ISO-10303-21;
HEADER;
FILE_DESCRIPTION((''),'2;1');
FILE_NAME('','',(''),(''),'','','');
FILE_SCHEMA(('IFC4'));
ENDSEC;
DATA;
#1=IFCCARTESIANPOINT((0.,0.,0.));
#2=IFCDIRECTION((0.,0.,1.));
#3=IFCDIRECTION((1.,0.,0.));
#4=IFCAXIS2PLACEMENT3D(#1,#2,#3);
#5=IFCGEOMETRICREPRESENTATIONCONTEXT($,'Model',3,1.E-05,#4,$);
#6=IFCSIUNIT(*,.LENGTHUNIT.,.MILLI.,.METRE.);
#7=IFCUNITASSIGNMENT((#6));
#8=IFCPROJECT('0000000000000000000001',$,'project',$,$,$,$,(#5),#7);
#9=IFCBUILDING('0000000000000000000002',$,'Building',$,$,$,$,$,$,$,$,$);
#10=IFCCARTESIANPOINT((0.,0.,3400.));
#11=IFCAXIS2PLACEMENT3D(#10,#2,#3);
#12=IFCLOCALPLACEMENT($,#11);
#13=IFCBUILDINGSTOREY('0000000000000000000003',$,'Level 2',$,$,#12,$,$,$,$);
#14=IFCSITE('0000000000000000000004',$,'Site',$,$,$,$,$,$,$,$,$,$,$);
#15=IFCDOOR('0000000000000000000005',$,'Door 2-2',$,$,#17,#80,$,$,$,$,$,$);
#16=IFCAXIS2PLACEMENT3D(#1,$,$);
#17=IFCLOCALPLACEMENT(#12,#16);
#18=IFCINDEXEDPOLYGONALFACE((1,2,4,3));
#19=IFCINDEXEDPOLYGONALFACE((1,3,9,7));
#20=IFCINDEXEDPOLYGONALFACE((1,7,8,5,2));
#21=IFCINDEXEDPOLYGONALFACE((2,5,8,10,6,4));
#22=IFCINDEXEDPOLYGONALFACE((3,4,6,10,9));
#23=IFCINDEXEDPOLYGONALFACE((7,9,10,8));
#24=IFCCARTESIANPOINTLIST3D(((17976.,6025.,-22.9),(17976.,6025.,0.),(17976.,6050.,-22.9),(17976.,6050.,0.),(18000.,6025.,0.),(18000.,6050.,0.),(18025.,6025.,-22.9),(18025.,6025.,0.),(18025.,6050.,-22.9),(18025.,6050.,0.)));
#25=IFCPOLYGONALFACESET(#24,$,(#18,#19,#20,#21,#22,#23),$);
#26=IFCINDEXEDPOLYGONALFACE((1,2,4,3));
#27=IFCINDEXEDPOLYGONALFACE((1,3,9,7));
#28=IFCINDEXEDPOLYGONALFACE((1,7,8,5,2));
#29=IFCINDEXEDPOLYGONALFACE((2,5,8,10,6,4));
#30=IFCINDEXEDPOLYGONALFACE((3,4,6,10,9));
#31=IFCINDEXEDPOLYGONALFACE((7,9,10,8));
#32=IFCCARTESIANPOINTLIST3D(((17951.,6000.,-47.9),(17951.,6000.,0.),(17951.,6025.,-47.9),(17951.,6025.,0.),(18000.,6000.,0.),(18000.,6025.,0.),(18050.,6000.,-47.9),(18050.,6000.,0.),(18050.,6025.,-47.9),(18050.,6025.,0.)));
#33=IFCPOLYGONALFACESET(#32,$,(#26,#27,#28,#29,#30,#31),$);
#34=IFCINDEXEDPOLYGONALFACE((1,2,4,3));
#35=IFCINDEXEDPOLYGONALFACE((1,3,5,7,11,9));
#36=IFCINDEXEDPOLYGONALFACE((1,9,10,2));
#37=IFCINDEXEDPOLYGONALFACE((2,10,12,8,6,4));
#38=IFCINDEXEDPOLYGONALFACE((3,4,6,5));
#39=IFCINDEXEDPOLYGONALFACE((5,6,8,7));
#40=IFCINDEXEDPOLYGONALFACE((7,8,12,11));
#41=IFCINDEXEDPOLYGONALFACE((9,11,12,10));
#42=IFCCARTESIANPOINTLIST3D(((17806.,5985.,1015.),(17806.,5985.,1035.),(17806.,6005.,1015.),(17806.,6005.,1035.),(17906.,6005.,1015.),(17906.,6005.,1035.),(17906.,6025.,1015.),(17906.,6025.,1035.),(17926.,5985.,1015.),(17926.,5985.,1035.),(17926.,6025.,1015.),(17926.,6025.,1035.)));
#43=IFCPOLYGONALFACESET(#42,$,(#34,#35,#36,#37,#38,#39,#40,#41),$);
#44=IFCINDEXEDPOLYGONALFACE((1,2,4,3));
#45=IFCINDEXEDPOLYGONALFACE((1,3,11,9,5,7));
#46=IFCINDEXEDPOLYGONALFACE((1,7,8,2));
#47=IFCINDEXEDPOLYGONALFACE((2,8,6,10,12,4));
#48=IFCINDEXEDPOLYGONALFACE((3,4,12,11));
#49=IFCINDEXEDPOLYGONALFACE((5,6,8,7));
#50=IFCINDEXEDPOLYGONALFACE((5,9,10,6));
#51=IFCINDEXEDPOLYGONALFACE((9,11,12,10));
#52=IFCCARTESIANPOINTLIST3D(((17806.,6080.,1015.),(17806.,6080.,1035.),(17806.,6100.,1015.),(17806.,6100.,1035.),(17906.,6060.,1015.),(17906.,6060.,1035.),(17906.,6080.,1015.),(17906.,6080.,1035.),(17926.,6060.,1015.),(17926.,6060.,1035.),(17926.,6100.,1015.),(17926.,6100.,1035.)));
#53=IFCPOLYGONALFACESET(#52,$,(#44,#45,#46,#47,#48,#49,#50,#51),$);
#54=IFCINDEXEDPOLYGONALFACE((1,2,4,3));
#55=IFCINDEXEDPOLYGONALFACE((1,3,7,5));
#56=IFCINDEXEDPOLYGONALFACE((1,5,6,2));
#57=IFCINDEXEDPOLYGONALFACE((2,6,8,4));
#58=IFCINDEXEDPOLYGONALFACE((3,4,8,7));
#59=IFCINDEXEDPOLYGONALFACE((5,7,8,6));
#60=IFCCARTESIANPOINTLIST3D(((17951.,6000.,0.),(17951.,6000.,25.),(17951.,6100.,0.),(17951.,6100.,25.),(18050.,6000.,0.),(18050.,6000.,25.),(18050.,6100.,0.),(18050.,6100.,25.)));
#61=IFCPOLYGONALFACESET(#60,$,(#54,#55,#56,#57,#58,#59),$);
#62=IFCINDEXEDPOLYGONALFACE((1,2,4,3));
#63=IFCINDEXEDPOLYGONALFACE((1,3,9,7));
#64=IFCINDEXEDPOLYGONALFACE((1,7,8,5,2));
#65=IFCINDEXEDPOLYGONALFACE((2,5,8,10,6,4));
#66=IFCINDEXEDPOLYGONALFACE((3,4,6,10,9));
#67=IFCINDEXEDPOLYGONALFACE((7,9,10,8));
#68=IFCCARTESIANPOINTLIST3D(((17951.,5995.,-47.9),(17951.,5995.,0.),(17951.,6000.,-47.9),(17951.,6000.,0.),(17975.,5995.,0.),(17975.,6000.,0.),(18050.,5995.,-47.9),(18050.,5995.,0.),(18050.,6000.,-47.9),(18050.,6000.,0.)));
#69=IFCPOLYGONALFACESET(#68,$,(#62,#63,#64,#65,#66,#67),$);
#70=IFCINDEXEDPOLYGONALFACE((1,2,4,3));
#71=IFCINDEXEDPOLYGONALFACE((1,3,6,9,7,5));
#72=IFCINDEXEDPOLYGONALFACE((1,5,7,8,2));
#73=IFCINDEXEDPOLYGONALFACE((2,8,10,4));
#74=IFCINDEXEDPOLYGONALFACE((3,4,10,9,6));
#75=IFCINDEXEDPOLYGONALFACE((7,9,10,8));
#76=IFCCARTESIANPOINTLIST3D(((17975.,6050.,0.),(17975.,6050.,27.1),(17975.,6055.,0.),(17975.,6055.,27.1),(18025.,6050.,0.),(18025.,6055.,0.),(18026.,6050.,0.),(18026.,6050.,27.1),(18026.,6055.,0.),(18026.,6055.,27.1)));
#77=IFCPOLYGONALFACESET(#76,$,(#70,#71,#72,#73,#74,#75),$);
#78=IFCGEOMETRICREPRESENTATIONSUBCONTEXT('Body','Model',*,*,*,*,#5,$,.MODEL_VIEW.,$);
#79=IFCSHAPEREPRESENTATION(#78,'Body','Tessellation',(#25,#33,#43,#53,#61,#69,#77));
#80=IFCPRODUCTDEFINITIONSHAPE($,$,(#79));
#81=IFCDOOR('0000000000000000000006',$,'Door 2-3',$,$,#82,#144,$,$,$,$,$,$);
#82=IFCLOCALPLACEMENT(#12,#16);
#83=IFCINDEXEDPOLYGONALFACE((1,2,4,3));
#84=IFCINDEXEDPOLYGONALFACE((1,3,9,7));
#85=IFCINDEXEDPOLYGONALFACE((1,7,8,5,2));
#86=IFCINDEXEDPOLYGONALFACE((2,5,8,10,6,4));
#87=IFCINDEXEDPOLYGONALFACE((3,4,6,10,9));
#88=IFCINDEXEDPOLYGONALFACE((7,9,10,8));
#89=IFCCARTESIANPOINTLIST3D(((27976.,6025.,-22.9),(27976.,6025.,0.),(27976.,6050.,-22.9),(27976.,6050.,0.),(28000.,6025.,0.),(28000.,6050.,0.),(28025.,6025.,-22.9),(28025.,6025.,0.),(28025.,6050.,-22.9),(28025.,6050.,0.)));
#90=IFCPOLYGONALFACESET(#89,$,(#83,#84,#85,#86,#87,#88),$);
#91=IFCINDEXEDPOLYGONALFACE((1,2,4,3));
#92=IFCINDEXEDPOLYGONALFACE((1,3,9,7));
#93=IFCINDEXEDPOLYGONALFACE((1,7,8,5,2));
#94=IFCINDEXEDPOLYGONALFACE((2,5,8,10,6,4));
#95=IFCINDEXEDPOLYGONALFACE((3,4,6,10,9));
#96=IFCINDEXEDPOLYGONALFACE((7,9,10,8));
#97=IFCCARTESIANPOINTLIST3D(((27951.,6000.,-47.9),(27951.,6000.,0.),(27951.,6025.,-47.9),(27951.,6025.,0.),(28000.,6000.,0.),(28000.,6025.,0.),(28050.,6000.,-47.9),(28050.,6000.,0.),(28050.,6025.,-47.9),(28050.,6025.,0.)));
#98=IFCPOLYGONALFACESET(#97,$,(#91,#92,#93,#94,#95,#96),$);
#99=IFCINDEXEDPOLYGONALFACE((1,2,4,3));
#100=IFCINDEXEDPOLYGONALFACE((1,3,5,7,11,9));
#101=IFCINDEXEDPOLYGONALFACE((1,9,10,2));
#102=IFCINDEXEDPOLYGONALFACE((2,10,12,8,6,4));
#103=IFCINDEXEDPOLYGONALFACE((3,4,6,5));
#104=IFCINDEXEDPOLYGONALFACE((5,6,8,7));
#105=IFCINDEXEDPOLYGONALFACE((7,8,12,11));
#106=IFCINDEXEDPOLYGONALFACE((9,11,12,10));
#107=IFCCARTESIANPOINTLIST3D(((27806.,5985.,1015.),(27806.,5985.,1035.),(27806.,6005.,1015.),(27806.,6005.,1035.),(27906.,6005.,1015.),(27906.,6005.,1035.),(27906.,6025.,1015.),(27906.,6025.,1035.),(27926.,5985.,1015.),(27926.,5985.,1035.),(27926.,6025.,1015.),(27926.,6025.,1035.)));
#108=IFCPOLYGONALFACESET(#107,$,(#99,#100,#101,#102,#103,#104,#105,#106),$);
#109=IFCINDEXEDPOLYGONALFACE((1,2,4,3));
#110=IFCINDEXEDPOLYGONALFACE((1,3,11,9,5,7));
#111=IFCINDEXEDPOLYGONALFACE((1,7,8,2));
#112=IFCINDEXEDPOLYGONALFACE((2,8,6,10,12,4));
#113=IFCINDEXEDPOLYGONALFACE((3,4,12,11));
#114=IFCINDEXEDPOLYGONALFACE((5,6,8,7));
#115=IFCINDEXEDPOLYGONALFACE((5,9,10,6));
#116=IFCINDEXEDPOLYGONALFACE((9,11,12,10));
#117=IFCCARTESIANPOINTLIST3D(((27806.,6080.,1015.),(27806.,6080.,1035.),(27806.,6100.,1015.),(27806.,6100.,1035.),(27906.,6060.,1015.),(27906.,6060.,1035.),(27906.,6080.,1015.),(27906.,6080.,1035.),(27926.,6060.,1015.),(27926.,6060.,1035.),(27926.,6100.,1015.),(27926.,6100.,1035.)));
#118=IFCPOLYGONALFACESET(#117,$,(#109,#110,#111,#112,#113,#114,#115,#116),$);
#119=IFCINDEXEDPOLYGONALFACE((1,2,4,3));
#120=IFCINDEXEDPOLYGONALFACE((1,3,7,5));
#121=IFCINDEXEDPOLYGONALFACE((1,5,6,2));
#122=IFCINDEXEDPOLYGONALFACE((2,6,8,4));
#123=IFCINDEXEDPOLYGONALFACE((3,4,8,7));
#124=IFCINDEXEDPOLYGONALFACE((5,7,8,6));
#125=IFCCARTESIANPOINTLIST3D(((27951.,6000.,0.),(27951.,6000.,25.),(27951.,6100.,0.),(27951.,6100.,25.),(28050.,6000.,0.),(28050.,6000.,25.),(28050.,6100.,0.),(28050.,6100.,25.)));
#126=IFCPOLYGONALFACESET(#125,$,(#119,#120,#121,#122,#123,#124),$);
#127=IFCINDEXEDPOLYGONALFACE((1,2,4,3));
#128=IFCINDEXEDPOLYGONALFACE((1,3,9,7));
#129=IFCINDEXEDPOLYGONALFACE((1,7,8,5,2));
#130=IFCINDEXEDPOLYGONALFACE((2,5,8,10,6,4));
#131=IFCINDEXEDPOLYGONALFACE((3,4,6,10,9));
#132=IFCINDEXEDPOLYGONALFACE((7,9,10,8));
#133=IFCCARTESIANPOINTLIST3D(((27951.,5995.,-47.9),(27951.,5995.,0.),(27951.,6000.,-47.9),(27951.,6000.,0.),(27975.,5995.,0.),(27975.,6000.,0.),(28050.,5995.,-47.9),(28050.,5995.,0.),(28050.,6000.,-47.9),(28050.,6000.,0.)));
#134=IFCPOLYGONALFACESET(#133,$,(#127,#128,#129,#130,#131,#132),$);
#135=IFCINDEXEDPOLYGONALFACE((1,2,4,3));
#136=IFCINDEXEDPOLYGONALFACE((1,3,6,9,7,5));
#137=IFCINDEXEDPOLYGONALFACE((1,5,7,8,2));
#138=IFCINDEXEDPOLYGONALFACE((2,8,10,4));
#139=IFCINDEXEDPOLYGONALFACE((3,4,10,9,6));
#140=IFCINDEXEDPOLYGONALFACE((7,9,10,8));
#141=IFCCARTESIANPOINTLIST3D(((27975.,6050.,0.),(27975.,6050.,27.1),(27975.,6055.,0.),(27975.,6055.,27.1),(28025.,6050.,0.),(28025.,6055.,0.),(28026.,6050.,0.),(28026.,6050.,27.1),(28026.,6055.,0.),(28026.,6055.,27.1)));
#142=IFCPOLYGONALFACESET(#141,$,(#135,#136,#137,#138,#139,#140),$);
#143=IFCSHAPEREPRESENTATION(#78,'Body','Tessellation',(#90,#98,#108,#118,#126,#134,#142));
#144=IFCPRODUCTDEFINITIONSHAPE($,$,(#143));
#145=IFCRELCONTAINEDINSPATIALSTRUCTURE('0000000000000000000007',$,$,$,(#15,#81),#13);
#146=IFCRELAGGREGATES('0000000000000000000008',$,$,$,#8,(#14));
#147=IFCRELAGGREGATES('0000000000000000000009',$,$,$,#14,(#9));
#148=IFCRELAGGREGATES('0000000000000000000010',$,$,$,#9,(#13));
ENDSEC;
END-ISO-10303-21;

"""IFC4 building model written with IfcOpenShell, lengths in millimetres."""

from ifc_helpers import new_model, si_unit, frame, origin_with_axes, place, context, subcontext, project, spatial, line, indexed_curve, outline, extrude, element, save


model = new_model("IFC4")

# Units and contexts
model_context = context("Model", 3, precision=1e-05, world=origin_with_axes())
body_context = subcontext(model_context, "Body", "Model", "MODEL_VIEW")
ifc_project = project(units=[si_unit("LENGTHUNIT", "METRE", prefix="MILLI")], contexts=[model_context])

# Site, building, storey
site = spatial("IfcSite", under=ifc_project, Name="Site")
building = spatial("IfcBuilding", under=site, Name="Building")
storey_placement = place(None, frame((0.0, 0.0, 3400.0), z_axis=(0.0, 0.0, 1.0), x_axis=(1.0, 0.0, 0.0)))
storey = spatial("IfcBuildingStorey", under=building, at=storey_placement, Name="Level 2")

# Doors
door_1_placement = place(storey_placement, frame((18000.0, 6000.0, 0.0), z_axis=(0.0, 0.0, 1.0), x_axis=(1.0, 0.0, 0.0)))
element("IfcDoor", 1, at=door_1_placement, inside=storey, Name="Door 2-2", context=body_context, shape_type="SweptSolid", body=[
    extrude(outline(indexed_curve([(0.0, 0.0), (0.0, 2.1), (1.0, 2.1), (1.0, 0.0), (-24.0, 0.0), (-24.0, -22.9), (25.0, -22.9), (25.0, 0.0)], segments=[line(1, 2, 3, 4, 5, 6, 7, 8, 1)])), frame((0.0, 25.0, 0.0), z_axis=(0.0, -1.0, 0.0), x_axis=(1.0, 0.0, 0.0)), (0.0, 0.0, -1.0), 25.0),
    extrude(outline(indexed_curve([(0.0, 0.0), (0.0, 2.1), (1.0, 2.1), (1.0, 0.0), (-49.0, 0.0), (-49.0, -47.9), (50.0, -47.9), (50.0, 0.0)], segments=[line(1, 2, 3, 4, 5, 6, 7, 8, 1)])), frame((0.0, 0.0, 0.0), z_axis=(0.0, -1.0, 0.0), x_axis=(1.0, 0.0, 0.0)), (0.0, 0.0, -1.0), 25.0),
    extrude(outline(indexed_curve([(0.0, 0.0), (-49.0, 0.0), (-49.0, 35.0), (0.0, 35.0)], segments=[line(1, 2, 3, 4, 1)])), frame((25.0, 25.0, 25.0), z_axis=(0.0, 0.0, 1.0), x_axis=(1.0, 0.0, 0.0)), (0.0, 0.0, 1.0), -47.9),
    extrude(outline(indexed_curve([(0.0, 0.0), (0.0, -40.0), (-120.0, -40.0), (-120.0, -20.0), (-20.0, -20.0), (-20.0, 0.0)], segments=[line(1, 2, 3, 4, 5, 6, 1)])), frame((-74.0, 25.0, 1015.0), z_axis=(0.0, 0.0, 1.0), x_axis=(1.0, 0.0, 0.0)), (0.0, 0.0, 1.0), 20.0),
    extrude(outline(indexed_curve([(0.0, 0.0), (0.0, 40.0), (-120.0, 40.0), (-120.0, 20.0), (-20.0, 20.0), (-20.0, 0.0)], segments=[line(1, 2, 3, 4, 5, 6, 1)])), frame((-74.0, 60.0, 1015.0), z_axis=(0.0, 0.0, 1.0), x_axis=(1.0, 0.0, 0.0)), (0.0, 0.0, 1.0), 20.0),
    extrude(outline(indexed_curve([(0.0, 0.0), (-99.0, 0.0), (-99.0, 100.0), (0.0, 100.0)], segments=[line(1, 2, 3, 4, 1)])), frame((50.0, 0.0, 0.0), z_axis=(0.0, 0.0, 1.0), x_axis=(1.0, 0.0, 0.0)), (0.0, 0.0, 1.0), 25.0),
    extrude(outline(indexed_curve([(0.0, 0.0), (0.0, 27.1), (51.0, 27.1), (51.0, 0.0), (-24.0, 0.0), (-24.0, -47.9), (75.0, -47.9), (75.0, 0.0)], segments=[line(1, 2, 3, 4, 5, 6, 7, 8, 1)])), frame((-25.0, -5.0, 0.0), z_axis=(0.0, -1.0, 0.0), x_axis=(1.0, 0.0, 0.0)), (0.0, 0.0, -1.0), 5.0),
    extrude(outline(indexed_curve([(0.0, 0.0), (0.0, 27.1), (51.0, 27.1), (51.0, 0.0), (1.0, 0.0), (1.0, -22.9), (50.0, -22.9), (50.0, 0.0)], segments=[line(1, 2, 3, 4, 5, 6, 7, 8, 1)])), frame((-25.0, 50.0, 0.0), z_axis=(0.0, -1.0, 0.0), x_axis=(1.0, 0.0, 0.0)), (0.0, 0.0, -1.0), 5.0),
])
door_2_placement = place(storey_placement, frame((28000.0, 6000.0, 0.0), z_axis=(0.0, 0.0, 1.0), x_axis=(1.0, 0.0, 0.0)))
element("IfcDoor", 2, at=door_2_placement, inside=storey, Name="Door 2-3", context=body_context, shape_type="SweptSolid", body=[
    extrude(outline(indexed_curve([(0.0, 0.0), (0.0, 2.1), (1.0, 2.1), (1.0, 0.0), (-24.0, 0.0), (-24.0, -22.9), (25.0, -22.9), (25.0, 0.0)], segments=[line(1, 2, 3, 4, 5, 6, 7, 8, 1)])), frame((0.0, 25.0, 0.0), z_axis=(0.0, -1.0, 0.0), x_axis=(1.0, 0.0, 0.0)), (0.0, 0.0, -1.0), 25.0),
    extrude(outline(indexed_curve([(0.0, 0.0), (0.0, 2.1), (1.0, 2.1), (1.0, 0.0), (-49.0, 0.0), (-49.0, -47.9), (50.0, -47.9), (50.0, 0.0)], segments=[line(1, 2, 3, 4, 5, 6, 7, 8, 1)])), frame((0.0, 0.0, 0.0), z_axis=(0.0, -1.0, 0.0), x_axis=(1.0, 0.0, 0.0)), (0.0, 0.0, -1.0), 25.0),
    extrude(outline(indexed_curve([(0.0, 0.0), (-49.0, 0.0), (-49.0, 35.0), (0.0, 35.0)], segments=[line(1, 2, 3, 4, 1)])), frame((25.0, 25.0, 25.0), z_axis=(0.0, 0.0, 1.0), x_axis=(1.0, 0.0, 0.0)), (0.0, 0.0, 1.0), -47.9),
    extrude(outline(indexed_curve([(0.0, 0.0), (0.0, -40.0), (-120.0, -40.0), (-120.0, -20.0), (-20.0, -20.0), (-20.0, 0.0)], segments=[line(1, 2, 3, 4, 5, 6, 1)])), frame((-74.0, 25.0, 1015.0), z_axis=(0.0, 0.0, 1.0), x_axis=(1.0, 0.0, 0.0)), (0.0, 0.0, 1.0), 20.0),
    extrude(outline(indexed_curve([(0.0, 0.0), (0.0, 40.0), (-120.0, 40.0), (-120.0, 20.0), (-20.0, 20.0), (-20.0, 0.0)], segments=[line(1, 2, 3, 4, 5, 6, 1)])), frame((-74.0, 60.0, 1015.0), z_axis=(0.0, 0.0, 1.0), x_axis=(1.0, 0.0, 0.0)), (0.0, 0.0, 1.0), 20.0),
    extrude(outline(indexed_curve([(0.0, 0.0), (-99.0, 0.0), (-99.0, 100.0), (0.0, 100.0)], segments=[line(1, 2, 3, 4, 1)])), frame((50.0, 0.0, 0.0), z_axis=(0.0, 0.0, 1.0), x_axis=(1.0, 0.0, 0.0)), (0.0, 0.0, 1.0), 25.0),
    extrude(outline(indexed_curve([(0.0, 0.0), (0.0, 27.1), (51.0, 27.1), (51.0, 0.0), (-24.0, 0.0), (-24.0, -47.9), (75.0, -47.9), (75.0, 0.0)], segments=[line(1, 2, 3, 4, 5, 6, 7, 8, 1)])), frame((-25.0, -5.0, 0.0), z_axis=(0.0, -1.0, 0.0), x_axis=(1.0, 0.0, 0.0)), (0.0, 0.0, -1.0), 5.0),
    extrude(outline(indexed_curve([(0.0, 0.0), (0.0, 27.1), (51.0, 27.1), (51.0, 0.0), (1.0, 0.0), (1.0, -22.9), (50.0, -22.9), (50.0, 0.0)], segments=[line(1, 2, 3, 4, 5, 6, 7, 8, 1)])), frame((-25.0, 50.0, 0.0), z_axis=(0.0, -1.0, 0.0), x_axis=(1.0, 0.0, 0.0)), (0.0, 0.0, -1.0), 5.0),
])

save(model, "model.ifc")
